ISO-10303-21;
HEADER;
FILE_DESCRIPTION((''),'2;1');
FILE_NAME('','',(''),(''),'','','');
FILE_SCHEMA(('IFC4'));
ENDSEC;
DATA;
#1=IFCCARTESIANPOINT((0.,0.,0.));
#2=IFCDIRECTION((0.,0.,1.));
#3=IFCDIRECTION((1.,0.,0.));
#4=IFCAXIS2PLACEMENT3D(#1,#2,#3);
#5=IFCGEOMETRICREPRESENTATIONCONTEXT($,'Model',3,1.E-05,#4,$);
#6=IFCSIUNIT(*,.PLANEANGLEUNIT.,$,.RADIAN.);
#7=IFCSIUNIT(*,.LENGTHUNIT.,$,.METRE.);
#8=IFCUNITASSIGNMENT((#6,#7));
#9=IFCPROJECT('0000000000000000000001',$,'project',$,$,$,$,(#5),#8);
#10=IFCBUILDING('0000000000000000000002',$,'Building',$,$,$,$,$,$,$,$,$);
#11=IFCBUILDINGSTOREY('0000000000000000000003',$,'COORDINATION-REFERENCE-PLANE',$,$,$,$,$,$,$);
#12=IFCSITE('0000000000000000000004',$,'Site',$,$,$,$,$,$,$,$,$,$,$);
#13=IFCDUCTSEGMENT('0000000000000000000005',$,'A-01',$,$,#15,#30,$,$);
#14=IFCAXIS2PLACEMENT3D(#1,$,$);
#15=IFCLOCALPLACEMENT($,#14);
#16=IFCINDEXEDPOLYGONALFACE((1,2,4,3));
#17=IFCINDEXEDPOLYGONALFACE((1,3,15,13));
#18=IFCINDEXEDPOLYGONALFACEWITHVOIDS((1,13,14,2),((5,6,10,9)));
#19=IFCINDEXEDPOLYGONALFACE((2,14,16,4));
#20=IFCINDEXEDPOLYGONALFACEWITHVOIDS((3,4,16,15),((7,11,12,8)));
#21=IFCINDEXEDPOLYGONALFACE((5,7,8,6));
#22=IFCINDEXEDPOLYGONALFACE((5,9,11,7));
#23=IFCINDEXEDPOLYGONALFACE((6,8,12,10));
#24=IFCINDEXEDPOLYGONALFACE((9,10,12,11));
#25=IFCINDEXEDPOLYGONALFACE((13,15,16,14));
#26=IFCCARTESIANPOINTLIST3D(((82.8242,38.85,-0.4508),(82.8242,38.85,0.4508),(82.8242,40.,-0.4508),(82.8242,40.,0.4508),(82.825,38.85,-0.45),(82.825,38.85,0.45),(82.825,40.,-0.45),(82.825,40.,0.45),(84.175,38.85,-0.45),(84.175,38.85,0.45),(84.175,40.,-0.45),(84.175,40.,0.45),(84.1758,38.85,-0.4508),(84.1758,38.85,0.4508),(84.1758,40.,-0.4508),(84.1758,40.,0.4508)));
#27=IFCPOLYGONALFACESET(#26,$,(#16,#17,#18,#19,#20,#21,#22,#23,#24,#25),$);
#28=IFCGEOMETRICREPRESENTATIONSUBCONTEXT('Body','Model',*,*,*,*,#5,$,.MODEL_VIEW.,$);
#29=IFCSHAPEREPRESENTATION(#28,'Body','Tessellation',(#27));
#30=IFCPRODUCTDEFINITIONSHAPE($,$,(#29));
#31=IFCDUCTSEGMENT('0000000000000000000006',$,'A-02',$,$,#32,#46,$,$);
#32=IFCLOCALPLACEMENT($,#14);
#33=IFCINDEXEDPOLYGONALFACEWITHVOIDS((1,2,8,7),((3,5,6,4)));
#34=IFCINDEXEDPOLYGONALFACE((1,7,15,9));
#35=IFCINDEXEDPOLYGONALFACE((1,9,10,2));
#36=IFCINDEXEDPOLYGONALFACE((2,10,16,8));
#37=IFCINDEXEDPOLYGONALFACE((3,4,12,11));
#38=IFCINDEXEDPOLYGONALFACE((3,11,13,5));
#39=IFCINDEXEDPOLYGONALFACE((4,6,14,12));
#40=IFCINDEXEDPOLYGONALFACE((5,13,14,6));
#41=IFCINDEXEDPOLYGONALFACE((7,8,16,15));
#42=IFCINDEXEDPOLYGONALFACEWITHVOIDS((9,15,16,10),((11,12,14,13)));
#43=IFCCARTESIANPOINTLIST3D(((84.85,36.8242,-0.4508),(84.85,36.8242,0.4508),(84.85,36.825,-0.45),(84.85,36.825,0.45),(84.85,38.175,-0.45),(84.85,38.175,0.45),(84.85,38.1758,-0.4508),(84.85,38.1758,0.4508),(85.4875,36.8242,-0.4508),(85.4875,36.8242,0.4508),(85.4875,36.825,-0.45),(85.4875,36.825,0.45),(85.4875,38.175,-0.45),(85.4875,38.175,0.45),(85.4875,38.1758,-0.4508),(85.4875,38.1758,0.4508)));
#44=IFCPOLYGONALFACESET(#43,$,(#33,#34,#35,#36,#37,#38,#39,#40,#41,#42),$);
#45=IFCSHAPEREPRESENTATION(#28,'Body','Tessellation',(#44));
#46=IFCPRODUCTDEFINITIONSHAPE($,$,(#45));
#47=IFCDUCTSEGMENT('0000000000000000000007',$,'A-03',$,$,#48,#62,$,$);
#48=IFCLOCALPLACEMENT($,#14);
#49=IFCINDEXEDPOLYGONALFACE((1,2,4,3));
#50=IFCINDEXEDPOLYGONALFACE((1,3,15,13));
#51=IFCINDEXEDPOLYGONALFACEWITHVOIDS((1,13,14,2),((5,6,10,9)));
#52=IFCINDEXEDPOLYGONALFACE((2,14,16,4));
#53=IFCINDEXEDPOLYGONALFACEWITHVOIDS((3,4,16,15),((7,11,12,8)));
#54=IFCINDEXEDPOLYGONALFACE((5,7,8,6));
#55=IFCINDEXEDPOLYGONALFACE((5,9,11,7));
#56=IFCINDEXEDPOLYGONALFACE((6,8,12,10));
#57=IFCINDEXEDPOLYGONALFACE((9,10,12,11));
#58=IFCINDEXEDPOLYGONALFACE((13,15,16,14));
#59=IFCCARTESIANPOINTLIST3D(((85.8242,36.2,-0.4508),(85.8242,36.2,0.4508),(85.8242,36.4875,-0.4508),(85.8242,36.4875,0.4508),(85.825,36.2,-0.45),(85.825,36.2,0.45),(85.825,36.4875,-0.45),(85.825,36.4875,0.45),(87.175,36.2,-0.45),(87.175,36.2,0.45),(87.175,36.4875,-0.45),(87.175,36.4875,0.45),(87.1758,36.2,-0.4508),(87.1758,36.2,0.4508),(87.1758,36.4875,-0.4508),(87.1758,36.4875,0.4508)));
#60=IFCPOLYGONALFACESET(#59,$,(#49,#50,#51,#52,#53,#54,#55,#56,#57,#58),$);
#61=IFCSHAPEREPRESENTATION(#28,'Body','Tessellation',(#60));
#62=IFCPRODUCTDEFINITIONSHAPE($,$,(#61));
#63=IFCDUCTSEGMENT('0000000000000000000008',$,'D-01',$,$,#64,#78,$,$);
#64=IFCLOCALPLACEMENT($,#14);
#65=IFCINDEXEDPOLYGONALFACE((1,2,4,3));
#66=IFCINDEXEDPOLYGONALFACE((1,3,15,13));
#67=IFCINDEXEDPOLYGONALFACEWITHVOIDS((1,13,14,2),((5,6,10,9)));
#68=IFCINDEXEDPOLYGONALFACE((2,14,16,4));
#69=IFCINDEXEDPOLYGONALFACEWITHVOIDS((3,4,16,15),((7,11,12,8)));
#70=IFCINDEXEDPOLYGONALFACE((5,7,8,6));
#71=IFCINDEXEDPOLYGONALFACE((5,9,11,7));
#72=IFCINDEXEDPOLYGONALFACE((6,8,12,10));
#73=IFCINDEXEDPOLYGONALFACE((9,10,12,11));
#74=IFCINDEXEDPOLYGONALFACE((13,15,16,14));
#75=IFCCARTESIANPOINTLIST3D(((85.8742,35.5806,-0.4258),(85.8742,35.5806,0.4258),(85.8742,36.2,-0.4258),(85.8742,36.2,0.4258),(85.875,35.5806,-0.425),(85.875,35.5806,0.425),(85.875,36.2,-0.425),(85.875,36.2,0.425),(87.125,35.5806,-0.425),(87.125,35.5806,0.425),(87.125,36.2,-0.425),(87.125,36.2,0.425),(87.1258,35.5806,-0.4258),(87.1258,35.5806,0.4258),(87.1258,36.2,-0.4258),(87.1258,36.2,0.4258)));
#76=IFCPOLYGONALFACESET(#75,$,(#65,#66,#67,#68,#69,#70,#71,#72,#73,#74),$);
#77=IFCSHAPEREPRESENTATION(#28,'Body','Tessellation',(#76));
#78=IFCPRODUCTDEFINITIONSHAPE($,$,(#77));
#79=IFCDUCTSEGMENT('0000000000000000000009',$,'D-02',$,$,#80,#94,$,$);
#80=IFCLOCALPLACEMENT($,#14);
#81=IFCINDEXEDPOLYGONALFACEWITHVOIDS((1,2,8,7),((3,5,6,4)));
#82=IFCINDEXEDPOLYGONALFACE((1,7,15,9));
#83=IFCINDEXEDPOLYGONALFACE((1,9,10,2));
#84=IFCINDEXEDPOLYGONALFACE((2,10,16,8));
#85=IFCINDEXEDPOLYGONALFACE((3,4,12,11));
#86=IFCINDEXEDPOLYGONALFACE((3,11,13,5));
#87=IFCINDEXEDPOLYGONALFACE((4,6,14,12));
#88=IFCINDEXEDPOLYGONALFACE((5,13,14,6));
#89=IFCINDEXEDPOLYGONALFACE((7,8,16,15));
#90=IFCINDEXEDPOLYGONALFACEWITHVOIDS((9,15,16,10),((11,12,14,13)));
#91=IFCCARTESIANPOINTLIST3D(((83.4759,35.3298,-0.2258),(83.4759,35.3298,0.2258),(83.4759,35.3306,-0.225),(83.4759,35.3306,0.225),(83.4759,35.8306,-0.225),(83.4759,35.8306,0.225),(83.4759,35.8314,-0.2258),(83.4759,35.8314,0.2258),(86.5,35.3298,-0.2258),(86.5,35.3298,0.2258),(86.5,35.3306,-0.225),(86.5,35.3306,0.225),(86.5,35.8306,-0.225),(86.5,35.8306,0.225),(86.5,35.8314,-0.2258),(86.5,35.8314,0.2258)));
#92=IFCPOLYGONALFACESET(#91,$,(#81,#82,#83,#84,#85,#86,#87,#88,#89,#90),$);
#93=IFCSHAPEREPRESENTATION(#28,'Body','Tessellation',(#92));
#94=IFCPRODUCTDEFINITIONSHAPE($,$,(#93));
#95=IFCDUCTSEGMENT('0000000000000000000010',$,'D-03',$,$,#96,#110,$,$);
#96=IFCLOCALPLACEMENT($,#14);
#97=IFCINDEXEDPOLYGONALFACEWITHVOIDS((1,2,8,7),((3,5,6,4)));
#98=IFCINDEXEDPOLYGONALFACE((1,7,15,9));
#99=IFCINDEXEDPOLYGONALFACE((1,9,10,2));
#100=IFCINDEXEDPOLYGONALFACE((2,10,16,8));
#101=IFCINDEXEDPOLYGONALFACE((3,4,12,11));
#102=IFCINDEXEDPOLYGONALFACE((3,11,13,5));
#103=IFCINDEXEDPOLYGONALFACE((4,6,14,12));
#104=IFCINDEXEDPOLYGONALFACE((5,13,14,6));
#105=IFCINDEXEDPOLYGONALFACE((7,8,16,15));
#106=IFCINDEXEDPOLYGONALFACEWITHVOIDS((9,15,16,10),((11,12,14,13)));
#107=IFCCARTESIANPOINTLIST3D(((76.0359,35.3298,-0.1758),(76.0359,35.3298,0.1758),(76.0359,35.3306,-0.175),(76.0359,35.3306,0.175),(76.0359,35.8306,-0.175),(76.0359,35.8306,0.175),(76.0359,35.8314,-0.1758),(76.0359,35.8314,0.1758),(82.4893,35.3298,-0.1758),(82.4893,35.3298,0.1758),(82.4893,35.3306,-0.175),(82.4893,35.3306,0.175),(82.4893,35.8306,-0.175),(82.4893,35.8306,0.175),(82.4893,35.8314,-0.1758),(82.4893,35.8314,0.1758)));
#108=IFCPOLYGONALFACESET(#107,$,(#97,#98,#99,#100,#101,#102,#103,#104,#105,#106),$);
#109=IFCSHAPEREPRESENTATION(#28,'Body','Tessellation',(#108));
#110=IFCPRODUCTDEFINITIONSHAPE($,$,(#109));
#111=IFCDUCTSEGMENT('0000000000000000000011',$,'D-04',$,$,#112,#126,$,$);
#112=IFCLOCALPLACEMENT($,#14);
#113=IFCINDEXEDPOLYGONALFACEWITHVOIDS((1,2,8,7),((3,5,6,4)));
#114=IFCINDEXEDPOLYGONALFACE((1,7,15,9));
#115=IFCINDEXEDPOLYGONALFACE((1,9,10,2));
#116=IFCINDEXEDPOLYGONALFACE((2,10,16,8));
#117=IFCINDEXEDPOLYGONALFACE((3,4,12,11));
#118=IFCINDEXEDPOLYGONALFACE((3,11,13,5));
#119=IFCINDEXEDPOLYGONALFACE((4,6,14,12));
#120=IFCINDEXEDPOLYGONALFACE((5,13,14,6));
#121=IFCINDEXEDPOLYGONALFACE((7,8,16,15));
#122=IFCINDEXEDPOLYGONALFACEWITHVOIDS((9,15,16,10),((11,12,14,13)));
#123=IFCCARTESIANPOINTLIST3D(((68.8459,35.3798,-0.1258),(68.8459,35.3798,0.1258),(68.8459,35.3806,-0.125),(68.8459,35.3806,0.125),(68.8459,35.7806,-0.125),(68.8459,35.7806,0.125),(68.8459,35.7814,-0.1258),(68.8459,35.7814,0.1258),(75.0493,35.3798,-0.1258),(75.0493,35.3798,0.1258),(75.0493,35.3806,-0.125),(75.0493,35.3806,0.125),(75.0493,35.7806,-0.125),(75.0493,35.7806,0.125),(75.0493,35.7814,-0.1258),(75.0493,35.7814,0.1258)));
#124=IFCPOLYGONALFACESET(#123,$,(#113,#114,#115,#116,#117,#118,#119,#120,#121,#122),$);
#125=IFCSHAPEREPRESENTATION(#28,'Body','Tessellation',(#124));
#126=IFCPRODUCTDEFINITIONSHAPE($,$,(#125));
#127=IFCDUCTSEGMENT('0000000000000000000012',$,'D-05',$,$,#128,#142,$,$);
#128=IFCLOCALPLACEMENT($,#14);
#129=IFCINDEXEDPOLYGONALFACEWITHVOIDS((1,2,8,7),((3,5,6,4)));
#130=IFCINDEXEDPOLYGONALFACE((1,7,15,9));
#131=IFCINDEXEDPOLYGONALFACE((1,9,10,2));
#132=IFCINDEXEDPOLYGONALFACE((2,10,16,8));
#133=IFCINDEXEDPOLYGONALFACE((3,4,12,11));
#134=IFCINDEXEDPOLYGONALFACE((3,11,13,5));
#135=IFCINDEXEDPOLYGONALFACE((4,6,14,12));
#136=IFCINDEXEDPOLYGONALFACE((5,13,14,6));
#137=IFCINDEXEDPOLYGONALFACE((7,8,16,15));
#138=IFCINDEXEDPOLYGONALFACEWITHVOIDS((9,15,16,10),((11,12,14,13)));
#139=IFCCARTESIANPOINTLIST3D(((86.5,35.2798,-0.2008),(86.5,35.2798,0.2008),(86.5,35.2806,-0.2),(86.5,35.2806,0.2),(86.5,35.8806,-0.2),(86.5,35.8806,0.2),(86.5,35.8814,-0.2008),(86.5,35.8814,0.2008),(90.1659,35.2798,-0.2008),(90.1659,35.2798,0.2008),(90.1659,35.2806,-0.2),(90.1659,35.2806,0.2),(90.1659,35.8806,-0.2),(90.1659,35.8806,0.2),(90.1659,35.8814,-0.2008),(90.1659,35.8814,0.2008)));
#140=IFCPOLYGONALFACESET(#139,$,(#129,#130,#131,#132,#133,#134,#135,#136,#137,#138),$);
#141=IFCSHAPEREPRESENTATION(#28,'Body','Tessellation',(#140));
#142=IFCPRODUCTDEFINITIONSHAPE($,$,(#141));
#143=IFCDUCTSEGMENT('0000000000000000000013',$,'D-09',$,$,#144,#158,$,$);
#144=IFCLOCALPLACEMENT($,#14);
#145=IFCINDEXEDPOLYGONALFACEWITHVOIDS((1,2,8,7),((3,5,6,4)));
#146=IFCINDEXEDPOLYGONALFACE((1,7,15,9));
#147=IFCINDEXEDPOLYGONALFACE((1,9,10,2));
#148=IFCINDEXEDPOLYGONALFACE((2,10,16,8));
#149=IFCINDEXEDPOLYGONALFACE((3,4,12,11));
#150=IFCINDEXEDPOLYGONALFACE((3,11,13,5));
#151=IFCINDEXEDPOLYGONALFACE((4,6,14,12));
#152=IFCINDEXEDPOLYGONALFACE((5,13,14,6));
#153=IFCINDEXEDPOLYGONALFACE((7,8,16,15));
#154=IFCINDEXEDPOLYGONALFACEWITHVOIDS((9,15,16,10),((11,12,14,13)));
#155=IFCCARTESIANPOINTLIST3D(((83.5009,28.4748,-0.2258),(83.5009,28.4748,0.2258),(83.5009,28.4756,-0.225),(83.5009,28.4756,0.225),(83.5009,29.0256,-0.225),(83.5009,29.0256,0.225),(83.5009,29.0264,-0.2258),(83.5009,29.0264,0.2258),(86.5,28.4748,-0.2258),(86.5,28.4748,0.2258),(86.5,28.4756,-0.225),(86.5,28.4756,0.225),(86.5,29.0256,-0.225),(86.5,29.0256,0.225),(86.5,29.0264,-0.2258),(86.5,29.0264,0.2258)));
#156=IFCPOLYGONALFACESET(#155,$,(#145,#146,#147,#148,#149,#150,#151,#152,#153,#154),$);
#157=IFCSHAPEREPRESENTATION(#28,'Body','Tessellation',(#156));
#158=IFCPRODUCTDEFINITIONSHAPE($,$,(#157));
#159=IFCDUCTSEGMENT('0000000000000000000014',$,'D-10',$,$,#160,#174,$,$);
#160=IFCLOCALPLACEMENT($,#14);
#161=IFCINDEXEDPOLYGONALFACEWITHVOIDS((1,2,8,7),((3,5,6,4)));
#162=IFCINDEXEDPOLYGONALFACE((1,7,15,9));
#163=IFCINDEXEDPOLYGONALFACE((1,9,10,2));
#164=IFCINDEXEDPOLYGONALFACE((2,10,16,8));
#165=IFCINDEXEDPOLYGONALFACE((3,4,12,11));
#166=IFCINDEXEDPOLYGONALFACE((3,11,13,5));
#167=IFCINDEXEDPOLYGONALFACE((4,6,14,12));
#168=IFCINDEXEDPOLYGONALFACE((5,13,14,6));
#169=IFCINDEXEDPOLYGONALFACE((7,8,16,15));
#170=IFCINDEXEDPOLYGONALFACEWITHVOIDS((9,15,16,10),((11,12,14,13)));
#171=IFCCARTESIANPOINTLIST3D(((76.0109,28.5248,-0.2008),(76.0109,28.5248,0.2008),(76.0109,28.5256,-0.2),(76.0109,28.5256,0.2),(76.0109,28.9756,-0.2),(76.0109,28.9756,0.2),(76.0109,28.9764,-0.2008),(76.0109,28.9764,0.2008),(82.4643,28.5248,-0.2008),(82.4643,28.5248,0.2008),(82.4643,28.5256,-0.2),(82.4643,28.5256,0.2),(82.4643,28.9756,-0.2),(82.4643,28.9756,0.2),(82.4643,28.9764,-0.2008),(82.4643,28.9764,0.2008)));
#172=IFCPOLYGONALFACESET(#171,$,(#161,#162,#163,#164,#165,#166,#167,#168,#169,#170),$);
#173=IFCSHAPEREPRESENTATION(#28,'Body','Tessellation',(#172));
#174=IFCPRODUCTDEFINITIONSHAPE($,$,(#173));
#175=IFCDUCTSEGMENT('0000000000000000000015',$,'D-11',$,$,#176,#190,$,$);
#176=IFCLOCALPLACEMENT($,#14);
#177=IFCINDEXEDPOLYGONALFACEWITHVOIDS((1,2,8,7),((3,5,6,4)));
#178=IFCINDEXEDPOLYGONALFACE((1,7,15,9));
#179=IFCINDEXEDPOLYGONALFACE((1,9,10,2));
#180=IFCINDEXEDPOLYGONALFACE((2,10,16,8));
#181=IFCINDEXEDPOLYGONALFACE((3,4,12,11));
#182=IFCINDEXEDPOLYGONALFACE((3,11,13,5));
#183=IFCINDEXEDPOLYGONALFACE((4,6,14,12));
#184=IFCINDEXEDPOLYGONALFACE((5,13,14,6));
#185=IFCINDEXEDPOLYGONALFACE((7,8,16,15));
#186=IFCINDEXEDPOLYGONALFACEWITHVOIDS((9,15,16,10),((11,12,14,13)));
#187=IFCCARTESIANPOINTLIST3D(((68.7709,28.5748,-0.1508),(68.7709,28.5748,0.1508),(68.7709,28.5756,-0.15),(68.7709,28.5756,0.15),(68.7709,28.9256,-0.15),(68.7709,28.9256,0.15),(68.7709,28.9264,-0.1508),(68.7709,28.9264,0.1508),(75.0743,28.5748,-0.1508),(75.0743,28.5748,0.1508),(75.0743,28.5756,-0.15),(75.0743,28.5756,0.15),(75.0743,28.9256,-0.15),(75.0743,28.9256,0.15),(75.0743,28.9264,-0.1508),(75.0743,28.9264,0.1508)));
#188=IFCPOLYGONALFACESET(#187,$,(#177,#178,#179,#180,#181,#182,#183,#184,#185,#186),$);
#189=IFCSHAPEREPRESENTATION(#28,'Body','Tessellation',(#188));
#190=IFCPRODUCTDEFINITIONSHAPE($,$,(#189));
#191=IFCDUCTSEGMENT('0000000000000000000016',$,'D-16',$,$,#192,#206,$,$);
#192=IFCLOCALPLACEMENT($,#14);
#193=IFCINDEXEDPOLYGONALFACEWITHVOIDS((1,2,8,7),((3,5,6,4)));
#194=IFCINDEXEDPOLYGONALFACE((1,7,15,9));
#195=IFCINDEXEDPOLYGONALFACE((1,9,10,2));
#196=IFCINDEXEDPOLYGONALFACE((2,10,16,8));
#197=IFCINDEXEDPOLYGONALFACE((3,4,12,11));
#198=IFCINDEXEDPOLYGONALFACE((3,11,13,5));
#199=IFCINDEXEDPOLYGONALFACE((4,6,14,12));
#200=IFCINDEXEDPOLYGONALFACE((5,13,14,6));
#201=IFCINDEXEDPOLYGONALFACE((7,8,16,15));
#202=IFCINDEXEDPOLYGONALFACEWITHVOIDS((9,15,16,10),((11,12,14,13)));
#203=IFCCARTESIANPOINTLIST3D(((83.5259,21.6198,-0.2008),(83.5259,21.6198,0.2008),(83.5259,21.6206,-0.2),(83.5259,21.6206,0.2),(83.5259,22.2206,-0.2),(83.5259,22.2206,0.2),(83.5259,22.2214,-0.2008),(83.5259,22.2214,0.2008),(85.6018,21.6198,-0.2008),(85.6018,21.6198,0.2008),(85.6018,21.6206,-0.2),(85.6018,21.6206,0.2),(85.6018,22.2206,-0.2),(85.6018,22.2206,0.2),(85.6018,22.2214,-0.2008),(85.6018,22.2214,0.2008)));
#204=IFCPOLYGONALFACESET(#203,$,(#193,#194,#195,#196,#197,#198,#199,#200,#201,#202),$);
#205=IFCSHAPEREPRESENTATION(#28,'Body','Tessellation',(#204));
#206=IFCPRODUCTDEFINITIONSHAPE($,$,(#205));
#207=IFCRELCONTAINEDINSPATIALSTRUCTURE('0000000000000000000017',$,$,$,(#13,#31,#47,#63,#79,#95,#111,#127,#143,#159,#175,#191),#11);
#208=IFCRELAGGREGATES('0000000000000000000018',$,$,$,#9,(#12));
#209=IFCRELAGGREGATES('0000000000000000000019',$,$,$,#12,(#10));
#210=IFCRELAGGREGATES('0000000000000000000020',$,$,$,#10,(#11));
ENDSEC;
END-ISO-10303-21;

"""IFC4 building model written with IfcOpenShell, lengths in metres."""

from ifc_helpers import new_model, si_unit, frame, origin, origin_with_axes, place, context, subcontext, project, spatial, hollow_rectangle, extrude, element, save


model = new_model("IFC4")

# Units and contexts
model_context = context("Model", 3, precision=1e-05, world=origin_with_axes())
body_context = subcontext(model_context, "Body", "Model", "MODEL_VIEW")
ifc_project = project(units=[si_unit("PLANEANGLEUNIT", "RADIAN"), si_unit("LENGTHUNIT", "METRE")], contexts=[model_context])

# Site, building, storey
site = spatial("IfcSite", under=ifc_project, Name="Site")
building = spatial("IfcBuilding", under=site, Name="Building")
storey = spatial("IfcBuildingStorey", under=building, Name="COORDINATION-REFERENCE-PLANE")

# Duct segments
duct_segment_1_placement = place(None, frame((83.5, 38.85, 0.0), z_axis=(0.0, 1.0, 0.0), x_axis=(1.0, 0.0, 0.0)))
element("IfcDuctSegment", 1, at=duct_segment_1_placement, inside=storey, Name="A-01", context=body_context, shape_type="SweptSolid", body=[
    extrude(hollow_rectangle(XDim=1.3516, YDim=0.9016, WallThickness=0.0008), origin(), (0.0, 0.0, 1.0), 1.15),
])
duct_segment_2_placement = place(None, frame((84.85, 37.5, 0.0), z_axis=(1.0, 0.0, 0.0), x_axis=(0.0, 1.0, 0.0)))
element("IfcDuctSegment", 2, at=duct_segment_2_placement, inside=storey, Name="A-02", context=body_context, shape_type="SweptSolid", body=[
    extrude(hollow_rectangle(XDim=1.3516, YDim=0.9016, WallThickness=0.0008), origin(), (0.0, 0.0, 1.0), 0.6375),
])
duct_segment_3_placement = place(None, frame((86.5, 36.2, 0.0), z_axis=(0.0, 1.0, 0.0), x_axis=(1.0, 0.0, 0.0)))
element("IfcDuctSegment", 3, at=duct_segment_3_placement, inside=storey, Name="A-03", context=body_context, shape_type="SweptSolid", body=[
    extrude(hollow_rectangle(XDim=1.3516, YDim=0.9016, WallThickness=0.0008), origin(), (0.0, 0.0, 1.0), 0.2875),
])
duct_segment_4_placement = place(None, frame((86.5, 35.5806, 0.0), z_axis=(0.0, 1.0, 0.0), x_axis=(1.0, 0.0, 0.0)))
element("IfcDuctSegment", 4, at=duct_segment_4_placement, inside=storey, Name="D-01", context=body_context, shape_type="SweptSolid", body=[
    extrude(hollow_rectangle(XDim=1.2516, YDim=0.8516, WallThickness=0.0008), origin(), (0.0, 0.0, 1.0), 0.6194),
])
duct_segment_5_placement = place(None, frame((83.4759, 35.5806, 0.0), z_axis=(1.0, 0.0, 0.0), x_axis=(0.0, 1.0, 0.0)))
element("IfcDuctSegment", 5, at=duct_segment_5_placement, inside=storey, Name="D-02", context=body_context, shape_type="SweptSolid", body=[
    extrude(hollow_rectangle(XDim=0.5016, YDim=0.4516, WallThickness=0.0008), origin(), (0.0, 0.0, 1.0), 3.0241),
])
duct_segment_6_placement = place(None, frame((76.0359, 35.5806, 0.0), z_axis=(1.0, 0.0, 0.0), x_axis=(0.0, 1.0, 0.0)))
element("IfcDuctSegment", 6, at=duct_segment_6_placement, inside=storey, Name="D-03", context=body_context, shape_type="SweptSolid", body=[
    extrude(hollow_rectangle(XDim=0.5016, YDim=0.3516, WallThickness=0.0008), origin(), (0.0, 0.0, 1.0), 6.4534),
])
duct_segment_7_placement = place(None, frame((68.8459, 35.5806, 0.0), z_axis=(1.0, 0.0, 0.0), x_axis=(0.0, 1.0, 0.0)))
element("IfcDuctSegment", 7, at=duct_segment_7_placement, inside=storey, Name="D-04", context=body_context, shape_type="SweptSolid", body=[
    extrude(hollow_rectangle(XDim=0.4016, YDim=0.2516, WallThickness=0.0008), origin(), (0.0, 0.0, 1.0), 6.2034),
])
duct_segment_8_placement = place(None, frame((86.5, 35.5806, 0.0), z_axis=(1.0, 0.0, 0.0), x_axis=(0.0, 1.0, 0.0)))
element("IfcDuctSegment", 8, at=duct_segment_8_placement, inside=storey, Name="D-05", context=body_context, shape_type="SweptSolid", body=[
    extrude(hollow_rectangle(XDim=0.6016, YDim=0.4016, WallThickness=0.0008), origin(), (0.0, 0.0, 1.0), 3.6659),
])
duct_segment_9_placement = place(None, frame((83.5009, 28.7506, 0.0), z_axis=(1.0, 0.0, 0.0), x_axis=(0.0, 1.0, 0.0)))
element("IfcDuctSegment", 9, at=duct_segment_9_placement, inside=storey, Name="D-09", context=body_context, shape_type="SweptSolid", body=[
    extrude(hollow_rectangle(XDim=0.5516, YDim=0.4516, WallThickness=0.0008), origin(), (0.0, 0.0, 1.0), 2.9991),
])
duct_segment_10_placement = place(None, frame((76.0109, 28.7506, 0.0), z_axis=(1.0, 0.0, 0.0), x_axis=(0.0, 1.0, 0.0)))
element("IfcDuctSegment", 10, at=duct_segment_10_placement, inside=storey, Name="D-10", context=body_context, shape_type="SweptSolid", body=[
    extrude(hollow_rectangle(XDim=0.4516, YDim=0.4016, WallThickness=0.0008), origin(), (0.0, 0.0, 1.0), 6.4534),
])
duct_segment_11_placement = place(None, frame((68.7709, 28.7506, 0.0), z_axis=(1.0, 0.0, 0.0), x_axis=(0.0, 1.0, 0.0)))
element("IfcDuctSegment", 11, at=duct_segment_11_placement, inside=storey, Name="D-11", context=body_context, shape_type="SweptSolid", body=[
    extrude(hollow_rectangle(XDim=0.3516, YDim=0.3016, WallThickness=0.0008), origin(), (0.0, 0.0, 1.0), 6.3034),
])
duct_segment_12_placement = place(None, frame((83.5259, 21.9206, 0.0), z_axis=(1.0, 0.0, 0.0), x_axis=(0.0, 1.0, 0.0)))
element("IfcDuctSegment", 12, at=duct_segment_12_placement, inside=storey, Name="D-16", context=body_context, shape_type="SweptSolid", body=[
    extrude(hollow_rectangle(XDim=0.6016, YDim=0.4016, WallThickness=0.0008), origin(), (0.0, 0.0, 1.0), 2.0759),
])

save(model, "model.ifc")
